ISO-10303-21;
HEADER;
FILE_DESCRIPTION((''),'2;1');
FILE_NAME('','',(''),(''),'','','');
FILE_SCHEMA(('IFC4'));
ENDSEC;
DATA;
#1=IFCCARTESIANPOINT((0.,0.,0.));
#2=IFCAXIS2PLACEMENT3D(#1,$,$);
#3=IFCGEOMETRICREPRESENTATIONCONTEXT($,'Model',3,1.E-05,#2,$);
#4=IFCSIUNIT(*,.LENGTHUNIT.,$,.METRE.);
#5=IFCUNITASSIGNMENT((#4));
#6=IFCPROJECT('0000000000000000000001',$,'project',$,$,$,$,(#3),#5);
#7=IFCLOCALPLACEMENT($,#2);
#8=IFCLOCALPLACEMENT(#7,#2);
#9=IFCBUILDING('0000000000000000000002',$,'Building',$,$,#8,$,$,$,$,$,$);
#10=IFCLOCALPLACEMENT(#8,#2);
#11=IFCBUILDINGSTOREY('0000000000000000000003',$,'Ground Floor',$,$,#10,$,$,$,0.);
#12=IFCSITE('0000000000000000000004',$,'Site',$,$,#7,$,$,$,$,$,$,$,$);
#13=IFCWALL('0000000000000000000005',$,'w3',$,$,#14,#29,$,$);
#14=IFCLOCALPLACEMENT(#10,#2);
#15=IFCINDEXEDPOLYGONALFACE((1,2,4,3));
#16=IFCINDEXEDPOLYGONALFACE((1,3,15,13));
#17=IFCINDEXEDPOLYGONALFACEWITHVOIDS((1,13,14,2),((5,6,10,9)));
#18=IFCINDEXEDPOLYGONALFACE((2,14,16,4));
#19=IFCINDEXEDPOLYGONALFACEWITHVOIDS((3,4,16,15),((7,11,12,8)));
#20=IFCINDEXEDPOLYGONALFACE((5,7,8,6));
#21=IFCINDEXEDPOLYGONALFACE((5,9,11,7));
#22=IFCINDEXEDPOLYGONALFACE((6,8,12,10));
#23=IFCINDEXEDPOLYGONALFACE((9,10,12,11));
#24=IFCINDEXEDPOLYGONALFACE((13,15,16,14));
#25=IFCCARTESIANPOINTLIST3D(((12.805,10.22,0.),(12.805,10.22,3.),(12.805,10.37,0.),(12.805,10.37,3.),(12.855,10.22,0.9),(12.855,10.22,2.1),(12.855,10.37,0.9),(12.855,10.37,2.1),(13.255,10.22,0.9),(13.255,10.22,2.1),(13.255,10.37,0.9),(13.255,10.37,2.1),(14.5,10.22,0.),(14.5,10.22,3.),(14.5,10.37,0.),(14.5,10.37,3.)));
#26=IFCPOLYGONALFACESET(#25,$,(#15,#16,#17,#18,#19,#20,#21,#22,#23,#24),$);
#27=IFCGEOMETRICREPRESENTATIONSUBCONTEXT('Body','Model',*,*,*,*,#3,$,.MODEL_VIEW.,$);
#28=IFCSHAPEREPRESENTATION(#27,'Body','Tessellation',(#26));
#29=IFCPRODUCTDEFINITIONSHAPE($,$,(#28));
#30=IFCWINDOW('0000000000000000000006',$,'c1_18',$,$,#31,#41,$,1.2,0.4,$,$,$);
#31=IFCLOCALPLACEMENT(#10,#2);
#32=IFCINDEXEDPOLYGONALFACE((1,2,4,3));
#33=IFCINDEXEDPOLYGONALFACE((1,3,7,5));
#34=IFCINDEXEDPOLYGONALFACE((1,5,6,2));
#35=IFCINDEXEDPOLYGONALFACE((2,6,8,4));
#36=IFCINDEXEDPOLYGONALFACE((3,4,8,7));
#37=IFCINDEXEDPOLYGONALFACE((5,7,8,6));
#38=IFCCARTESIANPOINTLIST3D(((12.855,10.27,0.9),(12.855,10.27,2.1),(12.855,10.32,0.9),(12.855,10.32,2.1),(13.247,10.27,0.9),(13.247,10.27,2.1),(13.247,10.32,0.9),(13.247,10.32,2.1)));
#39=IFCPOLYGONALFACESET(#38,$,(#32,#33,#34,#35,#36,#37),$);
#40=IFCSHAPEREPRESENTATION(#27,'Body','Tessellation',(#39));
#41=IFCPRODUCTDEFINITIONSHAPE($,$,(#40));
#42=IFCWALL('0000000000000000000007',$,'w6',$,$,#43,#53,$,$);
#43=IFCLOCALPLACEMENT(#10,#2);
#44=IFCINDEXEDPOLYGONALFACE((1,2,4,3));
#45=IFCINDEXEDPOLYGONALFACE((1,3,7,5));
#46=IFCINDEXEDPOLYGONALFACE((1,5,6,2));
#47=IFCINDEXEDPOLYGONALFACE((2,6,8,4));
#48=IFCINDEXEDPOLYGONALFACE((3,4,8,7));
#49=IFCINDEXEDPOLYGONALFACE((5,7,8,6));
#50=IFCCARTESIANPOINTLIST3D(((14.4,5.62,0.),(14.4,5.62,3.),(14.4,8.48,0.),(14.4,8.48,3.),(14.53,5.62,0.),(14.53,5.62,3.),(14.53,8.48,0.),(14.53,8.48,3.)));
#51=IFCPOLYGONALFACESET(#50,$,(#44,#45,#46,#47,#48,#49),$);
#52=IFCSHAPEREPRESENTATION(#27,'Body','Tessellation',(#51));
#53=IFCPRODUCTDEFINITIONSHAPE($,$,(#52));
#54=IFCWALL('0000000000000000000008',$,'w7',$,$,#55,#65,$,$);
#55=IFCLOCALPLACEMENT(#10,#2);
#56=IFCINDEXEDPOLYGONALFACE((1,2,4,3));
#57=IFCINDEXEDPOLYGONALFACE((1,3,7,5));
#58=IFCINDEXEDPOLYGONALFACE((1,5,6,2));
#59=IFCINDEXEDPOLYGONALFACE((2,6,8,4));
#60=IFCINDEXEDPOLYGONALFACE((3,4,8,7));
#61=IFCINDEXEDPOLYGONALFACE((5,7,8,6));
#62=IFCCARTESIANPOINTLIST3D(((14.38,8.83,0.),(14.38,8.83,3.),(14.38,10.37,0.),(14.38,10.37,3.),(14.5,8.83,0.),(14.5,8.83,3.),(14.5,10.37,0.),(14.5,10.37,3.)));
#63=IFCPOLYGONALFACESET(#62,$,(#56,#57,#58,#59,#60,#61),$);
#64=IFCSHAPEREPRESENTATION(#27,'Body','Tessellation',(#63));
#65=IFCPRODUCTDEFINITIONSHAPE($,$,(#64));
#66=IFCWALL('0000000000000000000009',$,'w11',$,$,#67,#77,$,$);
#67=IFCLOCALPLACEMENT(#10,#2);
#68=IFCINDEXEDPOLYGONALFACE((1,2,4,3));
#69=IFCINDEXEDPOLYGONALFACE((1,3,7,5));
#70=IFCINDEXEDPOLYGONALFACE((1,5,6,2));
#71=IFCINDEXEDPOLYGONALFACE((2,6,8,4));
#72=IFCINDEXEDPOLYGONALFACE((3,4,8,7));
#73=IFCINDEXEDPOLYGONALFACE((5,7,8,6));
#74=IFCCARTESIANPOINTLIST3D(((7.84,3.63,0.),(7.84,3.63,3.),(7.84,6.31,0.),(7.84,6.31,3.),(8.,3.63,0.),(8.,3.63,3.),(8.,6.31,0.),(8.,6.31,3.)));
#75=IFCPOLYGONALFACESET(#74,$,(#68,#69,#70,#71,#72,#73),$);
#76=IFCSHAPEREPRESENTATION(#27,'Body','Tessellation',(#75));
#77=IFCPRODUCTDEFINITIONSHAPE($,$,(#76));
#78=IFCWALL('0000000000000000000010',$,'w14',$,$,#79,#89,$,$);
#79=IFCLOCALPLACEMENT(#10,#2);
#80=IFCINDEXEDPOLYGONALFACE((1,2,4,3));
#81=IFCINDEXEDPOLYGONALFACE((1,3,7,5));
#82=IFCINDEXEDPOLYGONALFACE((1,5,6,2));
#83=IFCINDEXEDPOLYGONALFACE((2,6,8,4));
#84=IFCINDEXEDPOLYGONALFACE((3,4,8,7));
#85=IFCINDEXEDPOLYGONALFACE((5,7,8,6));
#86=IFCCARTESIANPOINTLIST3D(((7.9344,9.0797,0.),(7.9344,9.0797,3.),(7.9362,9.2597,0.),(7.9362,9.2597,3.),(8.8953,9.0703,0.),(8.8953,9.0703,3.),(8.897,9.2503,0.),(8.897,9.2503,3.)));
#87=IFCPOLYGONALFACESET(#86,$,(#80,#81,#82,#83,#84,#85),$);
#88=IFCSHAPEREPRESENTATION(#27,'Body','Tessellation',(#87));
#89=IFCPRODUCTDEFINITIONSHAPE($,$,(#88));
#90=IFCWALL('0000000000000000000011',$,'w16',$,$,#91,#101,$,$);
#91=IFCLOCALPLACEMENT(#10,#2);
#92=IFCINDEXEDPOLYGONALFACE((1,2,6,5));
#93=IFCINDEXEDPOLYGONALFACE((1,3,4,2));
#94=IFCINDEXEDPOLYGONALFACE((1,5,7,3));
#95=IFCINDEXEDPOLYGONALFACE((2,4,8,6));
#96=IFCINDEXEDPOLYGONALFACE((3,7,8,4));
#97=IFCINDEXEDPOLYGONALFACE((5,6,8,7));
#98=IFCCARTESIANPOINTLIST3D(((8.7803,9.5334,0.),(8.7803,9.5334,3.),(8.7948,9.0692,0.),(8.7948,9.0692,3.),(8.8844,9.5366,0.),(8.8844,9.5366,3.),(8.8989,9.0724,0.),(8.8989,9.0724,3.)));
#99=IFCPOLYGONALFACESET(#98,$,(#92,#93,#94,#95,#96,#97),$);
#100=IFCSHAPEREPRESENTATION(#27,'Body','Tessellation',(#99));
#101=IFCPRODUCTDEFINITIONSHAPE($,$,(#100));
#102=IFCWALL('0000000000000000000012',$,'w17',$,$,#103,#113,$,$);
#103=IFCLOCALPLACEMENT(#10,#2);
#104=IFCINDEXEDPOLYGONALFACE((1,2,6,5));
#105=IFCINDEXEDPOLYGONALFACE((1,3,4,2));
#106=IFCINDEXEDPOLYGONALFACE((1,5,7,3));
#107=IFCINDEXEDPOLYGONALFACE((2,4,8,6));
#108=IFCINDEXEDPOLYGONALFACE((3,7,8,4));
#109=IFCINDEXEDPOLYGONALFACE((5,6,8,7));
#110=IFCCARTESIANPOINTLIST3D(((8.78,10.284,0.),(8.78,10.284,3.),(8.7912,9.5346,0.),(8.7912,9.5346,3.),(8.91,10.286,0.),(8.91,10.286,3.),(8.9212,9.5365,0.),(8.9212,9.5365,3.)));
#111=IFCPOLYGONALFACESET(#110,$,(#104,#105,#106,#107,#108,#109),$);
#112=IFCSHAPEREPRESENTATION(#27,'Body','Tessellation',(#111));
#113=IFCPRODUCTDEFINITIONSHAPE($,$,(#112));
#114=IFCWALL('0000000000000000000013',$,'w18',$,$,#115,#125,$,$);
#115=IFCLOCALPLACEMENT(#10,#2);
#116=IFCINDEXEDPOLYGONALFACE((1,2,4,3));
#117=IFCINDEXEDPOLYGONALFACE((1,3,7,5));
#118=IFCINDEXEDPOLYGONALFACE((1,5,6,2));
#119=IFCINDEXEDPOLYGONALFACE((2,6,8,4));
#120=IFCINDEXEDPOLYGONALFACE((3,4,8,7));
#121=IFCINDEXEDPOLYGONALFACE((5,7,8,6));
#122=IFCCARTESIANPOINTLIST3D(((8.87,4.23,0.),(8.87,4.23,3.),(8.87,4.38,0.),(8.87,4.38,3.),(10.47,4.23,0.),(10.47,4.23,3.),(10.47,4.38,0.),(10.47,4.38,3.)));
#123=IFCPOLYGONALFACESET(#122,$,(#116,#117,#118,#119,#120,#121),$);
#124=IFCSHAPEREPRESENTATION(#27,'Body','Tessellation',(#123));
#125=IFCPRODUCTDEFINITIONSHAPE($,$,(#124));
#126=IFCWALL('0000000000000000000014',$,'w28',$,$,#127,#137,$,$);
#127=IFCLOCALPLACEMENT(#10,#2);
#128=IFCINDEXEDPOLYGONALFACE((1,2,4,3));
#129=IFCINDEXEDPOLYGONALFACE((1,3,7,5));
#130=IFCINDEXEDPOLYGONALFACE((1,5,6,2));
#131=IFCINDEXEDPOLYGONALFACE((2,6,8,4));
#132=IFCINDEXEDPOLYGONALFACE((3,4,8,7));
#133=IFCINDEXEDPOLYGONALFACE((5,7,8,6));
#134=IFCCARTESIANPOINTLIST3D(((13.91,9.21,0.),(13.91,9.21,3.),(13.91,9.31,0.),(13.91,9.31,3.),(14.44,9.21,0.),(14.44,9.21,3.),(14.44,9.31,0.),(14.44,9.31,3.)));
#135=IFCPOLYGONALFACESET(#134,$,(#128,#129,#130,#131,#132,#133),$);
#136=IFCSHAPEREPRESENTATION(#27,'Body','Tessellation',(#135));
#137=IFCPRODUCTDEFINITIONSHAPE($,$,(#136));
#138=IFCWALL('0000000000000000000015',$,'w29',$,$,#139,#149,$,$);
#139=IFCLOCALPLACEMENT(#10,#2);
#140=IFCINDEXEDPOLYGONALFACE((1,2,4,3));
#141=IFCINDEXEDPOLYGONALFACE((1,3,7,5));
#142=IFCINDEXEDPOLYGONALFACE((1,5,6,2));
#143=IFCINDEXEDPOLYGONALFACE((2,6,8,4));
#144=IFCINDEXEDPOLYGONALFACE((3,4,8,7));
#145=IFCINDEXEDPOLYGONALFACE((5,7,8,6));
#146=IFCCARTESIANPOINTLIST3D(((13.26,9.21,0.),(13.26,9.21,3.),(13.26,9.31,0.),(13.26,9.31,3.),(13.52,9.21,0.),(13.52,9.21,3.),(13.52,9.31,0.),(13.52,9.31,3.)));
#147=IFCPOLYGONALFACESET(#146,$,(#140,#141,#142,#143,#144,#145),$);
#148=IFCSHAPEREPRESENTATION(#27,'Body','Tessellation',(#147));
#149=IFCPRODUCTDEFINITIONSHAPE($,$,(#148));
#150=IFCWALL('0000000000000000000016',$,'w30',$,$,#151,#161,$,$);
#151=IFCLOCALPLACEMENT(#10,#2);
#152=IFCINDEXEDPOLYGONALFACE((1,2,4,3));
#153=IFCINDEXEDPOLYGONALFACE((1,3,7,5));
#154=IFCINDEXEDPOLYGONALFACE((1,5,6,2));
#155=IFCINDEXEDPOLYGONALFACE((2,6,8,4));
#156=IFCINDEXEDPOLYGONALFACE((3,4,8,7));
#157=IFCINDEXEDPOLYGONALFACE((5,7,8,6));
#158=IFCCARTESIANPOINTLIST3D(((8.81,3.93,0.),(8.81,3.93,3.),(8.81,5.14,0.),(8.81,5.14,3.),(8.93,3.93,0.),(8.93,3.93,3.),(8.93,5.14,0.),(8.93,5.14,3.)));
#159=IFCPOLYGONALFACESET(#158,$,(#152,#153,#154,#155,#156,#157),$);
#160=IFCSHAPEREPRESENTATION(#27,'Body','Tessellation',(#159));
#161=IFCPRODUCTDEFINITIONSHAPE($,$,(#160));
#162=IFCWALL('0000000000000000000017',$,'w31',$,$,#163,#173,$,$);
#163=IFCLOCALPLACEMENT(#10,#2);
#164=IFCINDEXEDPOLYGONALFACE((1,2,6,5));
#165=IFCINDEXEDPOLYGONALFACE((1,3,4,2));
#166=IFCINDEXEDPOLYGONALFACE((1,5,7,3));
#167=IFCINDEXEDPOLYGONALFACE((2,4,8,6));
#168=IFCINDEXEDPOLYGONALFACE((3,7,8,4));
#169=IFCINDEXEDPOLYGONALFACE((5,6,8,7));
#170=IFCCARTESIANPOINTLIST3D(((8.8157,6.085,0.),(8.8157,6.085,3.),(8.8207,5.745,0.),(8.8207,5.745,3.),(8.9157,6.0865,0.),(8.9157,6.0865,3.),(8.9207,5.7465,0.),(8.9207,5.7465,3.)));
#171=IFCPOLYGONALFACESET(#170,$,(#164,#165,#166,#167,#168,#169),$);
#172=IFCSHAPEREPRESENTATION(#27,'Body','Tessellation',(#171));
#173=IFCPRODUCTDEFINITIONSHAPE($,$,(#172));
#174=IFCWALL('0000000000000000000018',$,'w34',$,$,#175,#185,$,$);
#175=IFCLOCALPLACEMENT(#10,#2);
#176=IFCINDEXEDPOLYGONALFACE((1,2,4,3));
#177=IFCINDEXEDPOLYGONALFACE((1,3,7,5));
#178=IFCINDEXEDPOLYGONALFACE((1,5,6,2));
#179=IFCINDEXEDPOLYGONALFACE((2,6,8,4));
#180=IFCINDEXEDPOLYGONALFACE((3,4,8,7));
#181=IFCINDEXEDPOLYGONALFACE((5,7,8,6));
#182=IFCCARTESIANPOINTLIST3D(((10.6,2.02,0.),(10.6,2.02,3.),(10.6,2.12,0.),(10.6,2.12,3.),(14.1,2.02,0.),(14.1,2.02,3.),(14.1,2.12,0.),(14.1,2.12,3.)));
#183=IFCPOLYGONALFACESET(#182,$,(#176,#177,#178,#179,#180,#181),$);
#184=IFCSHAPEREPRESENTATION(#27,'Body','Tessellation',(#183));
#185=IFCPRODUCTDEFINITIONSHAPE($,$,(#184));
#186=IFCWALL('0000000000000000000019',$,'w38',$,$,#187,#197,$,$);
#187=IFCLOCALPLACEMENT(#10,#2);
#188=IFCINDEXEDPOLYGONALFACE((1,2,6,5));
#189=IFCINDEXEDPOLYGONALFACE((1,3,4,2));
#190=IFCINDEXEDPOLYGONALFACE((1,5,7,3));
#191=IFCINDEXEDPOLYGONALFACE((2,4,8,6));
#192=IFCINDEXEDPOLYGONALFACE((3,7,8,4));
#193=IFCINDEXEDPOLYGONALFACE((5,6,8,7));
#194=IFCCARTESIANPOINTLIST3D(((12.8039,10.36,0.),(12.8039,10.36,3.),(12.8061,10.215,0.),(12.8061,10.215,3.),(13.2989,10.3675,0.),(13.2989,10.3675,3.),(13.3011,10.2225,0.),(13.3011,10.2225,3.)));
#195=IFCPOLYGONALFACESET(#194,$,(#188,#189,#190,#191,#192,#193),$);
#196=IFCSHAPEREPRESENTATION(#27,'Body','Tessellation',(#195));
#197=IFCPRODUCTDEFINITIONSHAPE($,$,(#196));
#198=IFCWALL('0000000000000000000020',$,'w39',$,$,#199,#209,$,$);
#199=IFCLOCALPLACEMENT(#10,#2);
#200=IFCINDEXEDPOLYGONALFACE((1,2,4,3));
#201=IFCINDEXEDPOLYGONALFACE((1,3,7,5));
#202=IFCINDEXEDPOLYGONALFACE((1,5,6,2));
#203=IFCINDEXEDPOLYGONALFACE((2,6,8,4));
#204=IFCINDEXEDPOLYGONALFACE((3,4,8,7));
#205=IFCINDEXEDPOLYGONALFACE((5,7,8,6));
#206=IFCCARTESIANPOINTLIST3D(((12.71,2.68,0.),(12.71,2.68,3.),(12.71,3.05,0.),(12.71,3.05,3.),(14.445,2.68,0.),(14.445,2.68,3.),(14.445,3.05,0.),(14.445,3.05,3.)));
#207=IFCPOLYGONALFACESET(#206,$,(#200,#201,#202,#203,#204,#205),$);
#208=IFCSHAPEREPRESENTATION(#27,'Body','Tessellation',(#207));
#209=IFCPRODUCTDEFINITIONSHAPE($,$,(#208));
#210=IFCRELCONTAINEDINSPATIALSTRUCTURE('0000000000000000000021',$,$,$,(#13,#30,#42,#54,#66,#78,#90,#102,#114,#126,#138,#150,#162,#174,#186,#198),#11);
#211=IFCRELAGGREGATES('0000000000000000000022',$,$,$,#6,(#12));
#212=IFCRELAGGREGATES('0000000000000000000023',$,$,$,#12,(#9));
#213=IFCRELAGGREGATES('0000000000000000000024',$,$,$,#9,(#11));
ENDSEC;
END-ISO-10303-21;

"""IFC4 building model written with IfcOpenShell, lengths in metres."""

from ifc_helpers import new_model, si_unit, frame, origin, place, context, subcontext, project, spatial, polyline, outline, extrude, element, fill, save


model = new_model("IFC4")

# Units and contexts
model_context = context("Model", 3, precision=1e-05, world=origin())
body_context = subcontext(model_context, "Body", "Model", "MODEL_VIEW")
ifc_project = project(units=[si_unit("LENGTHUNIT", "METRE")], contexts=[model_context])

# Site, building, storey
site_placement = place(None, origin())
site = spatial("IfcSite", under=ifc_project, at=site_placement, Name="Site")
building_placement = place(site_placement, origin())
building = spatial("IfcBuilding", under=site, at=building_placement, Name="Building")
storey_placement = place(building_placement, origin())
storey = spatial("IfcBuildingStorey", under=building, at=storey_placement, Name="Ground Floor", Elevation=0.0)

# Wall, opening, window
wall_1_placement = place(storey_placement, frame((12.805, 10.295, 0.0), x_axis=(1.0, 0.0, 0.0)))
wall_1 = element("IfcWall", 1, at=wall_1_placement, inside=storey, Name="w3", context=body_context, shape_type="SweptSolid", body=[
    extrude(outline(polyline([(0.0, -0.075), (1.695, -0.075), (1.695, 0.075), (0.0, 0.075), (0.0, -0.075)])), origin(), (0.0, 0.0, 1.0), 3.0),
])
opening_1_placement = place(wall_1_placement, frame((0.05, 0.0, 0.0)))
opening_1 = element("IfcOpeningElement", 2, at=opening_1_placement, cuts=wall_1, context=body_context, shape_type="SweptSolid", body=[
    extrude(outline(polyline([(0.0, -0.0787), (0.4, -0.0787), (0.4, 0.0787), (0.0, 0.0787), (0.0, -0.0787)])), frame((0.0, 0.0, 0.9)), (0.0, 0.0, 1.0), 1.2),
])
window_placement = place(wall_1_placement, frame((0.05, 0.0, 0.0)))
window = element("IfcWindow", 3, at=window_placement, inside=storey, Name="c1_18", OverallHeight=1.2, OverallWidth=0.4, context=body_context, shape_type="SweptSolid", body=[
    extrude(outline(polyline([(0.0, -0.025), (0.392, -0.025), (0.392, 0.025), (0.0, 0.025), (0.0, -0.025)])), frame((0.0, 0.0, 0.9)), (0.0, 0.0, 1.0), 1.2),
])
fill(opening_1, window)

# Walls
wall_2_placement = place(storey_placement, frame((14.465, 5.62, 0.0), x_axis=(0.0, 1.0, 0.0)))
element("IfcWall", 4, at=wall_2_placement, inside=storey, Name="w6", context=body_context, shape_type="SweptSolid", body=[
    extrude(outline(polyline([(0.0, -0.065), (2.86, -0.065), (2.86, 0.065), (0.0, 0.065), (0.0, -0.065)])), origin(), (0.0, 0.0, 1.0), 3.0),
])
wall_3_placement = place(storey_placement, frame((14.44, 8.83, 0.0), x_axis=(0.0, 1.0, 0.0)))
element("IfcWall", 5, at=wall_3_placement, inside=storey, Name="w7", context=body_context, shape_type="SweptSolid", body=[
    extrude(outline(polyline([(0.0, -0.06), (1.54, -0.06), (1.54, 0.06), (0.0, 0.06), (0.0, -0.06)])), origin(), (0.0, 0.0, 1.0), 3.0),
])
wall_4_placement = place(storey_placement, frame((7.92, 3.63, 0.0), x_axis=(0.0, 1.0, 0.0)))
element("IfcWall", 6, at=wall_4_placement, inside=storey, Name="w11", context=body_context, shape_type="SweptSolid", body=[
    extrude(outline(polyline([(0.0, -0.08), (2.68, -0.08), (2.68, 0.08), (0.0, 0.08), (0.0, -0.08)])), origin(), (0.0, 0.0, 1.0), 3.0),
])
wall_5_placement = place(storey_placement, frame((7.9353, 9.1697, 0.0), x_axis=(0.999953, -0.009709, 0.0)))
element("IfcWall", 7, at=wall_5_placement, inside=storey, Name="w14", context=body_context, shape_type="SweptSolid", body=[
    extrude(outline(polyline([(0.0, -0.09), (0.9609, -0.09), (0.9609, 0.09), (0.0, 0.09), (0.0, -0.09)])), origin(), (0.0, 0.0, 1.0), 3.0),
])
wall_6_placement = place(storey_placement, frame((8.8323, 9.535, 0.0), x_axis=(0.031229, -0.999512, 0.0)))
element("IfcWall", 8, at=wall_6_placement, inside=storey, Name="w16", context=body_context, shape_type="SweptSolid", body=[
    extrude(outline(polyline([(0.0, -0.0521), (0.4644, -0.0521), (0.4644, 0.0521), (0.0, 0.0521), (0.0, -0.0521)])), origin(), (0.0, 0.0, 1.0), 3.0),
])
wall_7_placement = place(storey_placement, frame((8.845, 10.285, 0.0), x_axis=(0.014921, -0.999889, 0.0)))
element("IfcWall", 9, at=wall_7_placement, inside=storey, Name="w17", context=body_context, shape_type="SweptSolid", body=[
    extrude(outline(polyline([(0.0, -0.065), (0.7495, -0.065), (0.7495, 0.065), (0.0, 0.065), (0.0, -0.065)])), origin(), (0.0, 0.0, 1.0), 3.0),
])
wall_8_placement = place(storey_placement, frame((8.87, 4.305, 0.0), x_axis=(1.0, 0.0, 0.0)))
element("IfcWall", 10, at=wall_8_placement, inside=storey, Name="w18", context=body_context, shape_type="SweptSolid", body=[
    extrude(outline(polyline([(0.0, -0.075), (1.6, -0.075), (1.6, 0.075), (0.0, 0.075), (0.0, -0.075)])), origin(), (0.0, 0.0, 1.0), 3.0),
])
wall_9_placement = place(storey_placement, frame((13.91, 9.26, 0.0), x_axis=(1.0, 0.0, 0.0)))
element("IfcWall", 11, at=wall_9_placement, inside=storey, Name="w28", context=body_context, shape_type="SweptSolid", body=[
    extrude(outline(polyline([(0.0, -0.05), (0.53, -0.05), (0.53, 0.05), (0.0, 0.05), (0.0, -0.05)])), origin(), (0.0, 0.0, 1.0), 3.0),
])
wall_10_placement = place(storey_placement, frame((13.26, 9.26, 0.0), x_axis=(1.0, 0.0, 0.0)))
element("IfcWall", 12, at=wall_10_placement, inside=storey, Name="w29", context=body_context, shape_type="SweptSolid", body=[
    extrude(outline(polyline([(0.0, -0.05), (0.26, -0.05), (0.26, 0.05), (0.0, 0.05), (0.0, -0.05)])), origin(), (0.0, 0.0, 1.0), 3.0),
])
wall_11_placement = place(storey_placement, frame((8.87, 3.93, 0.0), x_axis=(0.0, 1.0, 0.0)))
element("IfcWall", 13, at=wall_11_placement, inside=storey, Name="w30", context=body_context, shape_type="SweptSolid", body=[
    extrude(outline(polyline([(0.0, -0.06), (1.21, -0.06), (1.21, 0.06), (0.0, 0.06), (0.0, -0.06)])), origin(), (0.0, 0.0, 1.0), 3.0),
])
wall_12_placement = place(storey_placement, frame((8.8707, 5.7457, 0.0), x_axis=(-0.014702, 0.999892, 0.0)))
element("IfcWall", 14, at=wall_12_placement, inside=storey, Name="w31", context=body_context, shape_type="SweptSolid", body=[
    extrude(outline(polyline([(0.0, -0.05), (0.34, -0.05), (0.34, 0.05), (0.0, 0.05), (0.0, -0.05)])), origin(), (0.0, 0.0, 1.0), 3.0),
])
wall_13_placement = place(storey_placement, frame((10.6, 2.07, 0.0), x_axis=(1.0, 0.0, 0.0)))
element("IfcWall", 15, at=wall_13_placement, inside=storey, Name="w34", context=body_context, shape_type="SweptSolid", body=[
    extrude(outline(polyline([(0.0, -0.05), (3.5, -0.05), (3.5, 0.05), (0.0, 0.05), (0.0, -0.05)])), origin(), (0.0, 0.0, 1.0), 3.0),
])
wall_14_placement = place(storey_placement, frame((12.805, 10.2875, 0.0), x_axis=(0.999885, 0.01515, 0.0)))
element("IfcWall", 16, at=wall_14_placement, inside=storey, Name="w38", context=body_context, shape_type="SweptSolid", body=[
    extrude(outline(polyline([(0.0, -0.0725), (0.4951, -0.0725), (0.4951, 0.0725), (0.0, 0.0725), (0.0, -0.0725)])), origin(), (0.0, 0.0, 1.0), 3.0),
])
wall_15_placement = place(storey_placement, frame((12.71, 2.865, 0.0), x_axis=(1.0, 0.0, 0.0)))
element("IfcWall", 17, at=wall_15_placement, inside=storey, Name="w39", context=body_context, shape_type="SweptSolid", body=[
    extrude(outline(polyline([(0.0, -0.185), (1.735, -0.185), (1.735, 0.185), (0.0, 0.185), (0.0, -0.185)])), origin(), (0.0, 0.0, 1.0), 3.0),
])

save(model, "model.ifc")
